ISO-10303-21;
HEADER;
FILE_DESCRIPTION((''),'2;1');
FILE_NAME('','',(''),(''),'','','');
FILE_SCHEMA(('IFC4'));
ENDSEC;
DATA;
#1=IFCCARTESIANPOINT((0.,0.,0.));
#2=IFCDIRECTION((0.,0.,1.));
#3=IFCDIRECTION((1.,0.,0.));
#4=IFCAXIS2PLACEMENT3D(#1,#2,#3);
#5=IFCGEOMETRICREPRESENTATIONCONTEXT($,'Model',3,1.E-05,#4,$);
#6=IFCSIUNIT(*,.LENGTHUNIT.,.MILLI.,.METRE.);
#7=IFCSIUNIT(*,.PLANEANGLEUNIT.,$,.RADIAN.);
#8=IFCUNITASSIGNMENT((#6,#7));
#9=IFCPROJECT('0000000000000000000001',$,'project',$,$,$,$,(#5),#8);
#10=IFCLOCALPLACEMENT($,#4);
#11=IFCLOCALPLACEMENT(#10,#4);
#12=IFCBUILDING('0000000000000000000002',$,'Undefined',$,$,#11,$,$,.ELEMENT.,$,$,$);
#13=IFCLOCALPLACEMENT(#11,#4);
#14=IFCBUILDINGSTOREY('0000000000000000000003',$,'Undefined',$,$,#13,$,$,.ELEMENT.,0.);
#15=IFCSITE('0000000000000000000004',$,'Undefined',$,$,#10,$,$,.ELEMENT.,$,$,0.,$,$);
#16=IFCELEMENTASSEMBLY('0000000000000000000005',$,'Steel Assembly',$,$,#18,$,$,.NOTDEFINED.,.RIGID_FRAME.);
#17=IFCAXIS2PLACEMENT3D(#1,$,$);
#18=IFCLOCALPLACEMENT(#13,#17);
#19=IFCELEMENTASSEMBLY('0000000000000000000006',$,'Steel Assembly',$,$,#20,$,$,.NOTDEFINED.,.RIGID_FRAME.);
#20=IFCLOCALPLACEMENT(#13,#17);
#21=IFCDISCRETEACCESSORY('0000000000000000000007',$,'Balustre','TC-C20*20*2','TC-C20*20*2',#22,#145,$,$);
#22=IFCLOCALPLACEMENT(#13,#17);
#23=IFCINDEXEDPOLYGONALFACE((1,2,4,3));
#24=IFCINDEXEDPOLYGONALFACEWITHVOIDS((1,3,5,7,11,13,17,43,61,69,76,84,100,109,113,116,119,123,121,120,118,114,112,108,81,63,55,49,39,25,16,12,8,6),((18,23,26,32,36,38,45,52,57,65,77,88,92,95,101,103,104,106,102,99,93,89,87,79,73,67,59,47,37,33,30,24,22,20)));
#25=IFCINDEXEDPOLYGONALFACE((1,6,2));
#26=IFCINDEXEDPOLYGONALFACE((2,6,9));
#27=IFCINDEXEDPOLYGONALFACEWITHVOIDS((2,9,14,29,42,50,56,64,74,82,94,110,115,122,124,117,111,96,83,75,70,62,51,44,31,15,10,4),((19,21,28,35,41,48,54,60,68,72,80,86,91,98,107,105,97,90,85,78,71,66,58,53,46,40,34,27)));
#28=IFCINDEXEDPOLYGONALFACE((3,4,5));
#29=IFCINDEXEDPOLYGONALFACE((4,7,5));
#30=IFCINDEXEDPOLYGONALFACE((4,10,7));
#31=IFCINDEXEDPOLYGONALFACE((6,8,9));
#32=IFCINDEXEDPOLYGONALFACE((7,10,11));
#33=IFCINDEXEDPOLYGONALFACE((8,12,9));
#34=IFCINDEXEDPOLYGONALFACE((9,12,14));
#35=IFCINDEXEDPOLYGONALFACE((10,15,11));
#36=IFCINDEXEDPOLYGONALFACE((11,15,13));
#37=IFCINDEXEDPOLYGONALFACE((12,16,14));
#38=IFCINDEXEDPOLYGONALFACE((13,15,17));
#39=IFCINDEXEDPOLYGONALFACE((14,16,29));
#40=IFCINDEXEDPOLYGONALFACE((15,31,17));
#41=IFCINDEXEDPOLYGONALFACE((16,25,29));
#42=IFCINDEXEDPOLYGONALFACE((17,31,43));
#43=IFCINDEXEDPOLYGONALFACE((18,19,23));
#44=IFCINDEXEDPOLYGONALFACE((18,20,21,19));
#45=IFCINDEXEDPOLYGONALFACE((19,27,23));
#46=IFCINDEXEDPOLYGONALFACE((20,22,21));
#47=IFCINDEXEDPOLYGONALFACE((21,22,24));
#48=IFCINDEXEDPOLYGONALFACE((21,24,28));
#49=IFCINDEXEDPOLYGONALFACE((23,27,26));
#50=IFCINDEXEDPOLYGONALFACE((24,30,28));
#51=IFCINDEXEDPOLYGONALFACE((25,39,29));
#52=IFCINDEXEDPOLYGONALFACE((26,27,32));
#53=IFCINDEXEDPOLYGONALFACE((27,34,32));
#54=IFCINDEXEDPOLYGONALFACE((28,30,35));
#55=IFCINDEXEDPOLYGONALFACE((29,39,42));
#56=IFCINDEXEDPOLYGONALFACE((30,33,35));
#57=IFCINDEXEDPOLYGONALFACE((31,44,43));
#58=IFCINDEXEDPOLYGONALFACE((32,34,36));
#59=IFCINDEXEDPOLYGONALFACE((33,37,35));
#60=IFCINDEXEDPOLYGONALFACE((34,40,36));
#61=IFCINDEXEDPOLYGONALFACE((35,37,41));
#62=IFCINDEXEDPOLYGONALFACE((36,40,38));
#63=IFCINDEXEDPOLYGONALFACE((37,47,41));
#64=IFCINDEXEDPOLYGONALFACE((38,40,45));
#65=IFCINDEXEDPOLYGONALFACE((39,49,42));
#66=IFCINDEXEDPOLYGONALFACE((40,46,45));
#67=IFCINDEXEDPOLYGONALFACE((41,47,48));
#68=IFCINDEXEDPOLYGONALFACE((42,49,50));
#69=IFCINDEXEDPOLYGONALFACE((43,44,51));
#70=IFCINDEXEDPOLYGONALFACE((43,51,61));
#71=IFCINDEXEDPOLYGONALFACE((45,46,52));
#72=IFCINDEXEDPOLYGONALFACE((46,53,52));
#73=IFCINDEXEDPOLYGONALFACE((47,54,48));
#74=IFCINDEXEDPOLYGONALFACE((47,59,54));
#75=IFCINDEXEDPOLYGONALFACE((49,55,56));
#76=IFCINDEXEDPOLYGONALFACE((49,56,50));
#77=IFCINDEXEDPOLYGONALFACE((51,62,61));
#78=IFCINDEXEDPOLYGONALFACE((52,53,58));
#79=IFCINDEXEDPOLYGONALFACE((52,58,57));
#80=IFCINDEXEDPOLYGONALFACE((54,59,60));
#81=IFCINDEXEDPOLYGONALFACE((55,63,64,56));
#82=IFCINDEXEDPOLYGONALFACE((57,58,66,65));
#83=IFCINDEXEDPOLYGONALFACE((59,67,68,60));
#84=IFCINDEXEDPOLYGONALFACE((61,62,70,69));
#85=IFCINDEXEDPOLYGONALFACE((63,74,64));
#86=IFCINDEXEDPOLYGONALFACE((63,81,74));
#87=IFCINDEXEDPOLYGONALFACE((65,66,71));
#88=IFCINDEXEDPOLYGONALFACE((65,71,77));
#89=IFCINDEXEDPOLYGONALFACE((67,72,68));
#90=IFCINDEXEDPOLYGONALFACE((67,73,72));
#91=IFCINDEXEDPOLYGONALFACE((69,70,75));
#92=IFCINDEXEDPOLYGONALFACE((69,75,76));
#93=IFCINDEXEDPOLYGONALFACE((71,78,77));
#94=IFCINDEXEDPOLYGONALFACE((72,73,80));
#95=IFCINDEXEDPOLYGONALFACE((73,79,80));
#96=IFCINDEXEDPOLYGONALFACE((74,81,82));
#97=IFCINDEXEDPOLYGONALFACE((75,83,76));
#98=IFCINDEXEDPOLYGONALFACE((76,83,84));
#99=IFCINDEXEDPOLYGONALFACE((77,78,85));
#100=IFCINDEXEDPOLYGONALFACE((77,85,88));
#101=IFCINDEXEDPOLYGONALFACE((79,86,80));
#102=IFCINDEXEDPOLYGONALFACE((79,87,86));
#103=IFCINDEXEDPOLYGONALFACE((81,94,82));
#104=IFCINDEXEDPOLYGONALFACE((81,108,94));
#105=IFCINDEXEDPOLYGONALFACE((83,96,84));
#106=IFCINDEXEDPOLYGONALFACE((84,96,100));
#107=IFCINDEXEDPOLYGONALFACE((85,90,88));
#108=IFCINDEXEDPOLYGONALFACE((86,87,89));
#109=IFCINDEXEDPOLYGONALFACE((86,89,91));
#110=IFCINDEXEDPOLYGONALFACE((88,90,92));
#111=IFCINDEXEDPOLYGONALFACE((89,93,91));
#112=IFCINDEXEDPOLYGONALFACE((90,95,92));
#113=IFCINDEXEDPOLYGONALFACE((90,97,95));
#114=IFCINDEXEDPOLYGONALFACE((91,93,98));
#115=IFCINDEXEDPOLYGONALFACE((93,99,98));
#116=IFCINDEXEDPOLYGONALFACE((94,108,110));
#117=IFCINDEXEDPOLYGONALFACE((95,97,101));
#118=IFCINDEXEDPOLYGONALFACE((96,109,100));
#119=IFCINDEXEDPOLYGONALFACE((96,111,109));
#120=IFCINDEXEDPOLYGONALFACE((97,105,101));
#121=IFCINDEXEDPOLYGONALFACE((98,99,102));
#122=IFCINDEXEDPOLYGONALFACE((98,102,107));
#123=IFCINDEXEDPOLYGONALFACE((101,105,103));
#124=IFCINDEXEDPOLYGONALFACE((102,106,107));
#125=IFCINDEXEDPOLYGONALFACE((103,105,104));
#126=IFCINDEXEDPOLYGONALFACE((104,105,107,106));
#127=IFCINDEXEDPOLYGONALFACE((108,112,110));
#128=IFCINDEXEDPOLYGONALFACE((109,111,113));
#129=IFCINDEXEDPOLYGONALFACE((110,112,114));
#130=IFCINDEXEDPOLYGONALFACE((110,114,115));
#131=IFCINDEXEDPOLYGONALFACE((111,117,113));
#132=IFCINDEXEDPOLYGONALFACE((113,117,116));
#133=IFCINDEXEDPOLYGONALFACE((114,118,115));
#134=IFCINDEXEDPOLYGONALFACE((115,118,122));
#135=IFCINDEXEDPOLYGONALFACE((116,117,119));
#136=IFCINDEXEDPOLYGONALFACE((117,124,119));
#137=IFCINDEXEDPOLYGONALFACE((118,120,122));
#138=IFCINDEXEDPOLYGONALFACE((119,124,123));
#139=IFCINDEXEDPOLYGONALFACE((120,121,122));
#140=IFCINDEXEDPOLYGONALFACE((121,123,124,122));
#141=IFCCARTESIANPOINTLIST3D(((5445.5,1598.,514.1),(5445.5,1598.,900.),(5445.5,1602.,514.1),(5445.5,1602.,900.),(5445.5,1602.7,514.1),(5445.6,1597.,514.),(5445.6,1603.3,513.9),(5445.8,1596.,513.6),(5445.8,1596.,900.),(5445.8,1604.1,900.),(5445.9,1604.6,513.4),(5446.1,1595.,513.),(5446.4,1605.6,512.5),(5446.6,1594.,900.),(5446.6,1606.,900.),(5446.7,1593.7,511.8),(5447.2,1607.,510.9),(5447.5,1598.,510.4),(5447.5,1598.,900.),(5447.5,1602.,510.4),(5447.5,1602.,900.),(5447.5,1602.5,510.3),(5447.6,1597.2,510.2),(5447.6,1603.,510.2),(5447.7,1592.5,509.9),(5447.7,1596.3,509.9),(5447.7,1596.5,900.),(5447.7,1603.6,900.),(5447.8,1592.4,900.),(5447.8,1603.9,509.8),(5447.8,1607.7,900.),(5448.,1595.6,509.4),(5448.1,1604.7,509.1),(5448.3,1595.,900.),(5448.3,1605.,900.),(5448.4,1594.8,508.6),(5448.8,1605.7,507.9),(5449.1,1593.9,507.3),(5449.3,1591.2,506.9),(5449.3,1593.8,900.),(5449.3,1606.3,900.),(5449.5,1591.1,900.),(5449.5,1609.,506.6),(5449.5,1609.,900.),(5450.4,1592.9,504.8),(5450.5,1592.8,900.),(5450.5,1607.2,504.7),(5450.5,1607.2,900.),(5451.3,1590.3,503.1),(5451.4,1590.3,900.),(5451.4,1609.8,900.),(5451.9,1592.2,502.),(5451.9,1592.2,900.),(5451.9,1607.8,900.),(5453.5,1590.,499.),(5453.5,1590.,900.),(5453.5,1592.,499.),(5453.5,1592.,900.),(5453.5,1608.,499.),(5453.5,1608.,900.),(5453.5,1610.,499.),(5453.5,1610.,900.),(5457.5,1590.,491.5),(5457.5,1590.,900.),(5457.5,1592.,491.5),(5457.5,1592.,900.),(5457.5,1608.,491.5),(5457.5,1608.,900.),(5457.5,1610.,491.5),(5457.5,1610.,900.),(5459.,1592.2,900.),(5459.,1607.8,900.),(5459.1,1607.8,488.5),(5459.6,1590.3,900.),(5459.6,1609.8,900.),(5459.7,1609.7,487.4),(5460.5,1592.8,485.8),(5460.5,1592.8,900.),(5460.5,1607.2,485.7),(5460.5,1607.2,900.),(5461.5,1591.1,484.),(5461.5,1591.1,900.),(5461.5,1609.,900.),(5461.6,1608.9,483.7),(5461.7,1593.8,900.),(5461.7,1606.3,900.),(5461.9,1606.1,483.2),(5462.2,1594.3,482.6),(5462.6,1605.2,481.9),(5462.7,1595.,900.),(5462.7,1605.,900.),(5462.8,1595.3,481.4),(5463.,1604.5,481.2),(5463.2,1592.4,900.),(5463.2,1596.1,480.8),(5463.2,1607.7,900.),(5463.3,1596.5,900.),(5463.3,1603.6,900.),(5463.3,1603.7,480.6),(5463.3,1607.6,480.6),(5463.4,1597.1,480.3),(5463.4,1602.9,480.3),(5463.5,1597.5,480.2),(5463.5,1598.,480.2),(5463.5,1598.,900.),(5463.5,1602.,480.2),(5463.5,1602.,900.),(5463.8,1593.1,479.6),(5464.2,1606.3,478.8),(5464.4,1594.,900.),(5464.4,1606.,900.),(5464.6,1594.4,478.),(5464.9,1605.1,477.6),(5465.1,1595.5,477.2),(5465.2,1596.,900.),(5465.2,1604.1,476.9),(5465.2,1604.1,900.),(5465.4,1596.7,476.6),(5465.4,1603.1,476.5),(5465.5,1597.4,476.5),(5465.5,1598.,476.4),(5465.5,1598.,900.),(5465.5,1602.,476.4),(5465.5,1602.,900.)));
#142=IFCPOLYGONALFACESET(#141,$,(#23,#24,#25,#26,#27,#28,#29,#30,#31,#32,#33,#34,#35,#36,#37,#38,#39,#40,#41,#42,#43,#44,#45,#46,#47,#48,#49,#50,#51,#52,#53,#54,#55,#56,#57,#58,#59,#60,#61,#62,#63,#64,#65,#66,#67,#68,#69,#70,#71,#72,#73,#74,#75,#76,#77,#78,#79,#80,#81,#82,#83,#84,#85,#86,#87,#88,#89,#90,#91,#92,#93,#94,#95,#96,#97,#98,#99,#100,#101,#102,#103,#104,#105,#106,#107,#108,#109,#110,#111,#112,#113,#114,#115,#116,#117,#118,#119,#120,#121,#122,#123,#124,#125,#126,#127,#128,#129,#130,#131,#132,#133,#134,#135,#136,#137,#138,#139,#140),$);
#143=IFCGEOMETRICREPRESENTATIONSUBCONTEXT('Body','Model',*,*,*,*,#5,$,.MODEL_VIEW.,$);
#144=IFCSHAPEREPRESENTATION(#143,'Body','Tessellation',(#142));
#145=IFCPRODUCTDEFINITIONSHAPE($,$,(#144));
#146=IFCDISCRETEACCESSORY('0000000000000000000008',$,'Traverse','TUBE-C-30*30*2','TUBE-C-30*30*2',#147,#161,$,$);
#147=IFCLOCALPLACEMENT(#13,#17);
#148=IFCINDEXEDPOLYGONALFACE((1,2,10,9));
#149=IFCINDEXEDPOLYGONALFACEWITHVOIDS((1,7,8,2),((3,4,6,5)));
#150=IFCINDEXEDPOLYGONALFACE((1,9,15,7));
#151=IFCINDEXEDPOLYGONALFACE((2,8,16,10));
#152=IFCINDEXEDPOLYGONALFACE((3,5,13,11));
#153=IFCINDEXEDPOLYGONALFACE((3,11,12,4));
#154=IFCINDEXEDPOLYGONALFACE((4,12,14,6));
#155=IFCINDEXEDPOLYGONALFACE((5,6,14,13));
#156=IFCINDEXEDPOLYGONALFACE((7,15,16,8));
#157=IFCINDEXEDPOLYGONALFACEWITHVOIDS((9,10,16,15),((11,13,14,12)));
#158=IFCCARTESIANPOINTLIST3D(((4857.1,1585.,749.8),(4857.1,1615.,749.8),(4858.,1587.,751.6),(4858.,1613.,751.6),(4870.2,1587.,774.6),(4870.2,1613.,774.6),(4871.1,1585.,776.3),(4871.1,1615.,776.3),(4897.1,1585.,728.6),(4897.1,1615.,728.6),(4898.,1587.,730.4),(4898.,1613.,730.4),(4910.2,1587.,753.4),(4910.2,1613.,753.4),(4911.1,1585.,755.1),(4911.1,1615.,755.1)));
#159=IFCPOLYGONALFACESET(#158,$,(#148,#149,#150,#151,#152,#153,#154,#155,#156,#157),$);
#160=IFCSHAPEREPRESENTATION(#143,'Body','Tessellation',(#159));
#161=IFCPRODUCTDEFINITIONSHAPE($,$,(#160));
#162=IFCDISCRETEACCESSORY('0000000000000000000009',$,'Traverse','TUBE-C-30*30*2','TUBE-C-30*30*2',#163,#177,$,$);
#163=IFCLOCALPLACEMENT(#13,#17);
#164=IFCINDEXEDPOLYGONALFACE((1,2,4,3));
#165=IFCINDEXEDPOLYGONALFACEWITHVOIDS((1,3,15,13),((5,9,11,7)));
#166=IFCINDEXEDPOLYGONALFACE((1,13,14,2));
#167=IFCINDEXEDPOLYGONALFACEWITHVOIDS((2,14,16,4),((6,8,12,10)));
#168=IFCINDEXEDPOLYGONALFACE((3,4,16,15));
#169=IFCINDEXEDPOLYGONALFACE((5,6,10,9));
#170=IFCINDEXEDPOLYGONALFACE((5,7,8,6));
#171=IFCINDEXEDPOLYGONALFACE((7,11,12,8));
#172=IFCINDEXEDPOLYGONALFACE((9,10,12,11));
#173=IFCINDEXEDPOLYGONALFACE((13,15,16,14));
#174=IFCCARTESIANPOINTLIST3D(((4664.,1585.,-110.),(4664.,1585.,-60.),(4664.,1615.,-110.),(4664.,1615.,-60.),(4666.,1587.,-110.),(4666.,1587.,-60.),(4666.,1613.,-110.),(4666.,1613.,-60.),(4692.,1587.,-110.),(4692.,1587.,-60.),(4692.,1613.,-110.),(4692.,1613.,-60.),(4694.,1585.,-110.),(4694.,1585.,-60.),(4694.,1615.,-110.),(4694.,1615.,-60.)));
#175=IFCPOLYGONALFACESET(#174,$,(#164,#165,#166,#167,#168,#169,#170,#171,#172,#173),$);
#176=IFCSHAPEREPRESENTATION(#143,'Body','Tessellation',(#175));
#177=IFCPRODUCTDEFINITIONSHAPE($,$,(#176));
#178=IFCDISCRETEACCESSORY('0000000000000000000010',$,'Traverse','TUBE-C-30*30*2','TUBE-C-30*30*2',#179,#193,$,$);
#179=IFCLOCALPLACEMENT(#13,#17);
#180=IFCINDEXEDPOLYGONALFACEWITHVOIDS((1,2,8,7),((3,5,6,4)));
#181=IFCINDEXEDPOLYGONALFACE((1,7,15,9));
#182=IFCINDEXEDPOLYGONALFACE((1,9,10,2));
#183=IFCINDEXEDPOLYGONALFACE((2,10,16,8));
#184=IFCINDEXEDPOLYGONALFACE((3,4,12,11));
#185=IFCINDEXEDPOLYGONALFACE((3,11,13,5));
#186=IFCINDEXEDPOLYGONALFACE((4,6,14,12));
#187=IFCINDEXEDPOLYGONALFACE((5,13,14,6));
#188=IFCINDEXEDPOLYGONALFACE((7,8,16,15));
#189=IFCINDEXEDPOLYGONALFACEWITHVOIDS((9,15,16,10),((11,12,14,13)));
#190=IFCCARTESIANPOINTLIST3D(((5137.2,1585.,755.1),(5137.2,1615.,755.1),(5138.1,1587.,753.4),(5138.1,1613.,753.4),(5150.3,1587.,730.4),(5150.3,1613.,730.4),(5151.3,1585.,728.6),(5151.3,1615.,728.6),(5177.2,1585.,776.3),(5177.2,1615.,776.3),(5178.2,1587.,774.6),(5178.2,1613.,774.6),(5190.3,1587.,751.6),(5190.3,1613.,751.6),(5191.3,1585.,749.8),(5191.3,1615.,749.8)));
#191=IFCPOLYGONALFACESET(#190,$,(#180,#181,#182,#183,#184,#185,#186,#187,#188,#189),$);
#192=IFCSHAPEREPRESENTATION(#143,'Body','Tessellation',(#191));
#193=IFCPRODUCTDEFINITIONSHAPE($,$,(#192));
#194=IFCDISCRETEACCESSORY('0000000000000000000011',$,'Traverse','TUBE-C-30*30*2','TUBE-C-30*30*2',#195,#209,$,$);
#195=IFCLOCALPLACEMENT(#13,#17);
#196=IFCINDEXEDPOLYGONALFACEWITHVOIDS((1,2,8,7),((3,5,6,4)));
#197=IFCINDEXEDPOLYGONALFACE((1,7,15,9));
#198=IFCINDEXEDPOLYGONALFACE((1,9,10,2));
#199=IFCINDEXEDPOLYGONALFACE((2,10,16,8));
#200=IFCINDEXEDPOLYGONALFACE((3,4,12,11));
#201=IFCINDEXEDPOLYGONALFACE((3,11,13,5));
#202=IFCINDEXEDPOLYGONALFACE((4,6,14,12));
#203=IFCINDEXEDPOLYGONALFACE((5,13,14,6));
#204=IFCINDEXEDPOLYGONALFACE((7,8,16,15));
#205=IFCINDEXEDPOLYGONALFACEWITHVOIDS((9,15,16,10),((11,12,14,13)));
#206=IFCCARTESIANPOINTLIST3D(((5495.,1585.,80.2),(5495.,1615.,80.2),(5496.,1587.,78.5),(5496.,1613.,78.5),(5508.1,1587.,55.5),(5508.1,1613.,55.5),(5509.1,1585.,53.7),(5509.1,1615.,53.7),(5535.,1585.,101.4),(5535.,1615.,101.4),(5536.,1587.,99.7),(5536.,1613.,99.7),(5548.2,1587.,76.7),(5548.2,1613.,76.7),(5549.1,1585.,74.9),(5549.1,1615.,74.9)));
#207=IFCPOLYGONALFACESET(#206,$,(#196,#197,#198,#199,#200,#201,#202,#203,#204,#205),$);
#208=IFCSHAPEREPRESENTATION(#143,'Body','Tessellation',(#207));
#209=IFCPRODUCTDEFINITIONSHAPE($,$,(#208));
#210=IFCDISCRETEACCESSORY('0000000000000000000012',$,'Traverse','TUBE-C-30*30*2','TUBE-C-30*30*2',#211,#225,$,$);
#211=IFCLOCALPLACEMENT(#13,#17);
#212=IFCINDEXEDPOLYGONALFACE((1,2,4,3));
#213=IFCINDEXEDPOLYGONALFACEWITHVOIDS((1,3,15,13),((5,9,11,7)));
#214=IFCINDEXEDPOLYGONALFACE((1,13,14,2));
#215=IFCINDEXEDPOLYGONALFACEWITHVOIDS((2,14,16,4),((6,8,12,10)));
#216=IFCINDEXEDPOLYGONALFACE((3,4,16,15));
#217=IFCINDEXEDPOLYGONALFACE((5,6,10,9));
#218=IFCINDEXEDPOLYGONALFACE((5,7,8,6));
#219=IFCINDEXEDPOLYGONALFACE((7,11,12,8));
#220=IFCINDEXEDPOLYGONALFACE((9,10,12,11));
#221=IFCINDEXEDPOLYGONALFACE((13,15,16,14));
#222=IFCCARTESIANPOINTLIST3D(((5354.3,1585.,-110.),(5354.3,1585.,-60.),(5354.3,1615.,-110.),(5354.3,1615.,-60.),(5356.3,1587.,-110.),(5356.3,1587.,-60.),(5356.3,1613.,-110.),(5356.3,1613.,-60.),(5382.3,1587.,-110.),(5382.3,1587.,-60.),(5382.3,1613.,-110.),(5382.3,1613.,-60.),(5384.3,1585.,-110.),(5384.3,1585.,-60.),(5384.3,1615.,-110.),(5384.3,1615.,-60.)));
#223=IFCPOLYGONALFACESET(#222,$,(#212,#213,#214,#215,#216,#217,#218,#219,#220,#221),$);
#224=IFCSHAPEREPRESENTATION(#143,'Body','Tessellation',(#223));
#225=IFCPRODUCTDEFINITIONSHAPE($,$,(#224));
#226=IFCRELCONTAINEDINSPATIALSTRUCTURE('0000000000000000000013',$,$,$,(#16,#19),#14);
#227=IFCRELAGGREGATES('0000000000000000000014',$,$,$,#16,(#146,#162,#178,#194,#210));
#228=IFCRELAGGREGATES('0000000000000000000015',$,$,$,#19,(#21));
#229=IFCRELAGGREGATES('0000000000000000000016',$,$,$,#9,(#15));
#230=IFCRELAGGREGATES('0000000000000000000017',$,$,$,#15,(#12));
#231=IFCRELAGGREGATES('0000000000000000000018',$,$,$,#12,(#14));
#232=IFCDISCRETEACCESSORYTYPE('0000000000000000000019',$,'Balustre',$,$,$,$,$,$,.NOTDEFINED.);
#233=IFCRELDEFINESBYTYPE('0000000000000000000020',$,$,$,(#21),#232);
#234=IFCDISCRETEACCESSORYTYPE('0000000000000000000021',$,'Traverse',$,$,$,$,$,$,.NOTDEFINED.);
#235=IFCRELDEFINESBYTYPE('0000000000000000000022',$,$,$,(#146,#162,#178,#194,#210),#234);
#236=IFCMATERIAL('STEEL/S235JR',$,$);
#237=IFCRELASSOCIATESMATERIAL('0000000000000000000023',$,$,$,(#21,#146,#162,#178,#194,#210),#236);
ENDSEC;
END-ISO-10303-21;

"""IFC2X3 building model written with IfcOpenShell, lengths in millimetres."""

from ifc_helpers import new_model, si_unit, frame, origin_with_axes, origin_2d_with_axis, place, context, subcontext, project, spatial, hollow_rectangle, extrude, clip, halfspace, material, type_object, element, aggregate, save


model = new_model("IFC2X3")

# Units and contexts
model_context = context("Model", 3, precision=1e-05, world=origin_with_axes())
body_context = subcontext(model_context, "Body", "Model", "MODEL_VIEW")
ifc_project = project(units=[si_unit("LENGTHUNIT", "METRE", prefix="MILLI"), si_unit("PLANEANGLEUNIT", "RADIAN")], contexts=[model_context])

# Site, building, storey
site_placement = place(None, origin_with_axes())
site = spatial("IfcSite", under=ifc_project, at=site_placement, Name="Undefined", CompositionType="ELEMENT", RefElevation=0.0)
building_placement = place(site_placement, origin_with_axes())
building = spatial("IfcBuilding", under=site, at=building_placement, Name="Undefined", CompositionType="ELEMENT")
storey_placement = place(building_placement, origin_with_axes())
storey = spatial("IfcBuildingStorey", under=building, at=storey_placement, Name="Undefined", CompositionType="ELEMENT", Elevation=0.0)

# Shared definitions
ifc_material = material(Name="STEEL/S235JR")

# Element assembly
assembly_1_placement = place(storey_placement, origin_with_axes())
assembly_1 = element("IfcElementAssembly", 1, at=assembly_1_placement, inside=storey, Name="Steel Assembly", AssemblyPlace="NOTDEFINED", PredefinedType="RIGID_FRAME")
discrete_accessory_type_1 = type_object("IfcDiscreteAccessoryType", Name="Balustre")

# Element assembly, discrete accessory
assembly_2_placement = place(storey_placement, origin_with_axes())
assembly_2 = element("IfcElementAssembly", 2, at=assembly_2_placement, inside=storey, Name="Steel Assembly", AssemblyPlace="NOTDEFINED", PredefinedType="RIGID_FRAME")
discrete_accessory_1_placement = place(assembly_2_placement, frame((5455.5, 1600.0, 900.0), z_axis=(0.0, 1.0, 0.0), x_axis=(0.0, 0.0, -1.0)))
discrete_accessory_1 = element("IfcDiscreteAccessory", 3, at=discrete_accessory_1_placement, type_object=discrete_accessory_type_1, material=ifc_material, Name="Balustre", Description="TC-C20*20*2", ObjectType="TC-C20*20*2", context=body_context, shape_type="Clipping", body=[
    clip(extrude(hollow_rectangle(XDim=20.0, YDim=20.0, WallThickness=2.0, InnerFilletRadius=6.0, OuterFilletRadius=8.0, at=origin_2d_with_axis()), frame((423.8, 0.0, 0.0), z_axis=(-1.0, 0.0, 0.0), x_axis=(0.0, -1.0, 0.0)), (0.0, 0.0, 1.0), 423.8), halfspace(frame((285.4, 63.3, 0.0), z_axis=(-0.46842, -0.883506, 0.000005), x_axis=(0.0, 0.000005, 1.0)), True)),
])

# Discrete accessories
discrete_accessory_type_2 = type_object("IfcDiscreteAccessoryType", Name="Traverse")
discrete_accessory_2_placement = place(assembly_1_placement, frame((4904.1, 1600.0, 741.9), z_axis=(-0.000011, 1.0, 0.0), x_axis=(-0.883506, -0.00001, 0.46842)))
discrete_accessory_2 = element("IfcDiscreteAccessory", 4, at=discrete_accessory_2_placement, type_object=discrete_accessory_type_2, material=ifc_material, Name="Traverse", Description="TUBE-C-30*30*2", ObjectType="TUBE-C-30*30*2", context=body_context, shape_type="SweptSolid", body=[
    extrude(hollow_rectangle(XDim=30.0, YDim=30.0, WallThickness=2.0, at=origin_2d_with_axis()), frame((45.3, 0.0, 0.0), z_axis=(-1.0, 0.0, 0.0), x_axis=(0.0, -1.0, 0.0)), (0.0, 0.0, 1.0), 45.3),
])
discrete_accessory_3_placement = place(assembly_1_placement, frame((4679.0, 1600.0, -60.0), z_axis=(-0.000011, 1.0, 0.0), x_axis=(0.0, 0.0, -1.0)))
discrete_accessory_3 = element("IfcDiscreteAccessory", 5, at=discrete_accessory_3_placement, type_object=discrete_accessory_type_2, material=ifc_material, Name="Traverse", Description="TUBE-C-30*30*2", ObjectType="TUBE-C-30*30*2", context=body_context, shape_type="SweptSolid", body=[
    extrude(hollow_rectangle(XDim=30.0, YDim=30.0, WallThickness=2.0, at=origin_2d_with_axis()), frame((50.0, 0.0, 0.0), z_axis=(-1.0, 0.0, 0.0), x_axis=(0.0, -1.0, 0.0)), (0.0, 0.0, 1.0), 50.0),
])
discrete_accessory_4_placement = place(assembly_1_placement, frame((5144.2, 1600.0, 741.9), z_axis=(-0.000011, 1.0, 0.0), x_axis=(0.883506, 0.00001, 0.46842)))
discrete_accessory_4 = element("IfcDiscreteAccessory", 6, at=discrete_accessory_4_placement, type_object=discrete_accessory_type_2, material=ifc_material, Name="Traverse", Description="TUBE-C-30*30*2", ObjectType="TUBE-C-30*30*2", context=body_context, shape_type="SweptSolid", body=[
    extrude(hollow_rectangle(XDim=30.0, YDim=30.0, WallThickness=2.0, at=origin_2d_with_axis()), frame((45.3, 0.0, 0.0), z_axis=(-1.0, 0.0, 0.0), x_axis=(0.0, -1.0, 0.0)), (0.0, 0.0, 1.0), 45.3),
])
discrete_accessory_5_placement = place(assembly_1_placement, frame((5502.0, 1600.0, 67.0), z_axis=(-0.000011, 1.0, 0.0), x_axis=(0.883506, 0.00001, 0.46842)))
discrete_accessory_5 = element("IfcDiscreteAccessory", 7, at=discrete_accessory_5_placement, type_object=discrete_accessory_type_2, material=ifc_material, Name="Traverse", Description="TUBE-C-30*30*2", ObjectType="TUBE-C-30*30*2", context=body_context, shape_type="SweptSolid", body=[
    extrude(hollow_rectangle(XDim=30.0, YDim=30.0, WallThickness=2.0, at=origin_2d_with_axis()), frame((45.3, 0.0, 0.0), z_axis=(-1.0, 0.0, 0.0), x_axis=(0.0, -1.0, 0.0)), (0.0, 0.0, 1.0), 45.3),
])
discrete_accessory_6_placement = place(assembly_1_placement, frame((5369.3, 1600.0, -60.0), z_axis=(-0.000011, 1.0, 0.0), x_axis=(0.0, 0.0, -1.0)))
discrete_accessory_6 = element("IfcDiscreteAccessory", 8, at=discrete_accessory_6_placement, type_object=discrete_accessory_type_2, material=ifc_material, Name="Traverse", Description="TUBE-C-30*30*2", ObjectType="TUBE-C-30*30*2", context=body_context, shape_type="SweptSolid", body=[
    extrude(hollow_rectangle(XDim=30.0, YDim=30.0, WallThickness=2.0, at=origin_2d_with_axis()), frame((50.0, 0.0, 0.0), z_axis=(-1.0, 0.0, 0.0), x_axis=(0.0, -1.0, 0.0)), (0.0, 0.0, 1.0), 50.0),
])
aggregate(assembly_1, [discrete_accessory_2, discrete_accessory_3, discrete_accessory_4, discrete_accessory_5, discrete_accessory_6])
aggregate(assembly_2, [discrete_accessory_1])

save(model, "model.ifc")
